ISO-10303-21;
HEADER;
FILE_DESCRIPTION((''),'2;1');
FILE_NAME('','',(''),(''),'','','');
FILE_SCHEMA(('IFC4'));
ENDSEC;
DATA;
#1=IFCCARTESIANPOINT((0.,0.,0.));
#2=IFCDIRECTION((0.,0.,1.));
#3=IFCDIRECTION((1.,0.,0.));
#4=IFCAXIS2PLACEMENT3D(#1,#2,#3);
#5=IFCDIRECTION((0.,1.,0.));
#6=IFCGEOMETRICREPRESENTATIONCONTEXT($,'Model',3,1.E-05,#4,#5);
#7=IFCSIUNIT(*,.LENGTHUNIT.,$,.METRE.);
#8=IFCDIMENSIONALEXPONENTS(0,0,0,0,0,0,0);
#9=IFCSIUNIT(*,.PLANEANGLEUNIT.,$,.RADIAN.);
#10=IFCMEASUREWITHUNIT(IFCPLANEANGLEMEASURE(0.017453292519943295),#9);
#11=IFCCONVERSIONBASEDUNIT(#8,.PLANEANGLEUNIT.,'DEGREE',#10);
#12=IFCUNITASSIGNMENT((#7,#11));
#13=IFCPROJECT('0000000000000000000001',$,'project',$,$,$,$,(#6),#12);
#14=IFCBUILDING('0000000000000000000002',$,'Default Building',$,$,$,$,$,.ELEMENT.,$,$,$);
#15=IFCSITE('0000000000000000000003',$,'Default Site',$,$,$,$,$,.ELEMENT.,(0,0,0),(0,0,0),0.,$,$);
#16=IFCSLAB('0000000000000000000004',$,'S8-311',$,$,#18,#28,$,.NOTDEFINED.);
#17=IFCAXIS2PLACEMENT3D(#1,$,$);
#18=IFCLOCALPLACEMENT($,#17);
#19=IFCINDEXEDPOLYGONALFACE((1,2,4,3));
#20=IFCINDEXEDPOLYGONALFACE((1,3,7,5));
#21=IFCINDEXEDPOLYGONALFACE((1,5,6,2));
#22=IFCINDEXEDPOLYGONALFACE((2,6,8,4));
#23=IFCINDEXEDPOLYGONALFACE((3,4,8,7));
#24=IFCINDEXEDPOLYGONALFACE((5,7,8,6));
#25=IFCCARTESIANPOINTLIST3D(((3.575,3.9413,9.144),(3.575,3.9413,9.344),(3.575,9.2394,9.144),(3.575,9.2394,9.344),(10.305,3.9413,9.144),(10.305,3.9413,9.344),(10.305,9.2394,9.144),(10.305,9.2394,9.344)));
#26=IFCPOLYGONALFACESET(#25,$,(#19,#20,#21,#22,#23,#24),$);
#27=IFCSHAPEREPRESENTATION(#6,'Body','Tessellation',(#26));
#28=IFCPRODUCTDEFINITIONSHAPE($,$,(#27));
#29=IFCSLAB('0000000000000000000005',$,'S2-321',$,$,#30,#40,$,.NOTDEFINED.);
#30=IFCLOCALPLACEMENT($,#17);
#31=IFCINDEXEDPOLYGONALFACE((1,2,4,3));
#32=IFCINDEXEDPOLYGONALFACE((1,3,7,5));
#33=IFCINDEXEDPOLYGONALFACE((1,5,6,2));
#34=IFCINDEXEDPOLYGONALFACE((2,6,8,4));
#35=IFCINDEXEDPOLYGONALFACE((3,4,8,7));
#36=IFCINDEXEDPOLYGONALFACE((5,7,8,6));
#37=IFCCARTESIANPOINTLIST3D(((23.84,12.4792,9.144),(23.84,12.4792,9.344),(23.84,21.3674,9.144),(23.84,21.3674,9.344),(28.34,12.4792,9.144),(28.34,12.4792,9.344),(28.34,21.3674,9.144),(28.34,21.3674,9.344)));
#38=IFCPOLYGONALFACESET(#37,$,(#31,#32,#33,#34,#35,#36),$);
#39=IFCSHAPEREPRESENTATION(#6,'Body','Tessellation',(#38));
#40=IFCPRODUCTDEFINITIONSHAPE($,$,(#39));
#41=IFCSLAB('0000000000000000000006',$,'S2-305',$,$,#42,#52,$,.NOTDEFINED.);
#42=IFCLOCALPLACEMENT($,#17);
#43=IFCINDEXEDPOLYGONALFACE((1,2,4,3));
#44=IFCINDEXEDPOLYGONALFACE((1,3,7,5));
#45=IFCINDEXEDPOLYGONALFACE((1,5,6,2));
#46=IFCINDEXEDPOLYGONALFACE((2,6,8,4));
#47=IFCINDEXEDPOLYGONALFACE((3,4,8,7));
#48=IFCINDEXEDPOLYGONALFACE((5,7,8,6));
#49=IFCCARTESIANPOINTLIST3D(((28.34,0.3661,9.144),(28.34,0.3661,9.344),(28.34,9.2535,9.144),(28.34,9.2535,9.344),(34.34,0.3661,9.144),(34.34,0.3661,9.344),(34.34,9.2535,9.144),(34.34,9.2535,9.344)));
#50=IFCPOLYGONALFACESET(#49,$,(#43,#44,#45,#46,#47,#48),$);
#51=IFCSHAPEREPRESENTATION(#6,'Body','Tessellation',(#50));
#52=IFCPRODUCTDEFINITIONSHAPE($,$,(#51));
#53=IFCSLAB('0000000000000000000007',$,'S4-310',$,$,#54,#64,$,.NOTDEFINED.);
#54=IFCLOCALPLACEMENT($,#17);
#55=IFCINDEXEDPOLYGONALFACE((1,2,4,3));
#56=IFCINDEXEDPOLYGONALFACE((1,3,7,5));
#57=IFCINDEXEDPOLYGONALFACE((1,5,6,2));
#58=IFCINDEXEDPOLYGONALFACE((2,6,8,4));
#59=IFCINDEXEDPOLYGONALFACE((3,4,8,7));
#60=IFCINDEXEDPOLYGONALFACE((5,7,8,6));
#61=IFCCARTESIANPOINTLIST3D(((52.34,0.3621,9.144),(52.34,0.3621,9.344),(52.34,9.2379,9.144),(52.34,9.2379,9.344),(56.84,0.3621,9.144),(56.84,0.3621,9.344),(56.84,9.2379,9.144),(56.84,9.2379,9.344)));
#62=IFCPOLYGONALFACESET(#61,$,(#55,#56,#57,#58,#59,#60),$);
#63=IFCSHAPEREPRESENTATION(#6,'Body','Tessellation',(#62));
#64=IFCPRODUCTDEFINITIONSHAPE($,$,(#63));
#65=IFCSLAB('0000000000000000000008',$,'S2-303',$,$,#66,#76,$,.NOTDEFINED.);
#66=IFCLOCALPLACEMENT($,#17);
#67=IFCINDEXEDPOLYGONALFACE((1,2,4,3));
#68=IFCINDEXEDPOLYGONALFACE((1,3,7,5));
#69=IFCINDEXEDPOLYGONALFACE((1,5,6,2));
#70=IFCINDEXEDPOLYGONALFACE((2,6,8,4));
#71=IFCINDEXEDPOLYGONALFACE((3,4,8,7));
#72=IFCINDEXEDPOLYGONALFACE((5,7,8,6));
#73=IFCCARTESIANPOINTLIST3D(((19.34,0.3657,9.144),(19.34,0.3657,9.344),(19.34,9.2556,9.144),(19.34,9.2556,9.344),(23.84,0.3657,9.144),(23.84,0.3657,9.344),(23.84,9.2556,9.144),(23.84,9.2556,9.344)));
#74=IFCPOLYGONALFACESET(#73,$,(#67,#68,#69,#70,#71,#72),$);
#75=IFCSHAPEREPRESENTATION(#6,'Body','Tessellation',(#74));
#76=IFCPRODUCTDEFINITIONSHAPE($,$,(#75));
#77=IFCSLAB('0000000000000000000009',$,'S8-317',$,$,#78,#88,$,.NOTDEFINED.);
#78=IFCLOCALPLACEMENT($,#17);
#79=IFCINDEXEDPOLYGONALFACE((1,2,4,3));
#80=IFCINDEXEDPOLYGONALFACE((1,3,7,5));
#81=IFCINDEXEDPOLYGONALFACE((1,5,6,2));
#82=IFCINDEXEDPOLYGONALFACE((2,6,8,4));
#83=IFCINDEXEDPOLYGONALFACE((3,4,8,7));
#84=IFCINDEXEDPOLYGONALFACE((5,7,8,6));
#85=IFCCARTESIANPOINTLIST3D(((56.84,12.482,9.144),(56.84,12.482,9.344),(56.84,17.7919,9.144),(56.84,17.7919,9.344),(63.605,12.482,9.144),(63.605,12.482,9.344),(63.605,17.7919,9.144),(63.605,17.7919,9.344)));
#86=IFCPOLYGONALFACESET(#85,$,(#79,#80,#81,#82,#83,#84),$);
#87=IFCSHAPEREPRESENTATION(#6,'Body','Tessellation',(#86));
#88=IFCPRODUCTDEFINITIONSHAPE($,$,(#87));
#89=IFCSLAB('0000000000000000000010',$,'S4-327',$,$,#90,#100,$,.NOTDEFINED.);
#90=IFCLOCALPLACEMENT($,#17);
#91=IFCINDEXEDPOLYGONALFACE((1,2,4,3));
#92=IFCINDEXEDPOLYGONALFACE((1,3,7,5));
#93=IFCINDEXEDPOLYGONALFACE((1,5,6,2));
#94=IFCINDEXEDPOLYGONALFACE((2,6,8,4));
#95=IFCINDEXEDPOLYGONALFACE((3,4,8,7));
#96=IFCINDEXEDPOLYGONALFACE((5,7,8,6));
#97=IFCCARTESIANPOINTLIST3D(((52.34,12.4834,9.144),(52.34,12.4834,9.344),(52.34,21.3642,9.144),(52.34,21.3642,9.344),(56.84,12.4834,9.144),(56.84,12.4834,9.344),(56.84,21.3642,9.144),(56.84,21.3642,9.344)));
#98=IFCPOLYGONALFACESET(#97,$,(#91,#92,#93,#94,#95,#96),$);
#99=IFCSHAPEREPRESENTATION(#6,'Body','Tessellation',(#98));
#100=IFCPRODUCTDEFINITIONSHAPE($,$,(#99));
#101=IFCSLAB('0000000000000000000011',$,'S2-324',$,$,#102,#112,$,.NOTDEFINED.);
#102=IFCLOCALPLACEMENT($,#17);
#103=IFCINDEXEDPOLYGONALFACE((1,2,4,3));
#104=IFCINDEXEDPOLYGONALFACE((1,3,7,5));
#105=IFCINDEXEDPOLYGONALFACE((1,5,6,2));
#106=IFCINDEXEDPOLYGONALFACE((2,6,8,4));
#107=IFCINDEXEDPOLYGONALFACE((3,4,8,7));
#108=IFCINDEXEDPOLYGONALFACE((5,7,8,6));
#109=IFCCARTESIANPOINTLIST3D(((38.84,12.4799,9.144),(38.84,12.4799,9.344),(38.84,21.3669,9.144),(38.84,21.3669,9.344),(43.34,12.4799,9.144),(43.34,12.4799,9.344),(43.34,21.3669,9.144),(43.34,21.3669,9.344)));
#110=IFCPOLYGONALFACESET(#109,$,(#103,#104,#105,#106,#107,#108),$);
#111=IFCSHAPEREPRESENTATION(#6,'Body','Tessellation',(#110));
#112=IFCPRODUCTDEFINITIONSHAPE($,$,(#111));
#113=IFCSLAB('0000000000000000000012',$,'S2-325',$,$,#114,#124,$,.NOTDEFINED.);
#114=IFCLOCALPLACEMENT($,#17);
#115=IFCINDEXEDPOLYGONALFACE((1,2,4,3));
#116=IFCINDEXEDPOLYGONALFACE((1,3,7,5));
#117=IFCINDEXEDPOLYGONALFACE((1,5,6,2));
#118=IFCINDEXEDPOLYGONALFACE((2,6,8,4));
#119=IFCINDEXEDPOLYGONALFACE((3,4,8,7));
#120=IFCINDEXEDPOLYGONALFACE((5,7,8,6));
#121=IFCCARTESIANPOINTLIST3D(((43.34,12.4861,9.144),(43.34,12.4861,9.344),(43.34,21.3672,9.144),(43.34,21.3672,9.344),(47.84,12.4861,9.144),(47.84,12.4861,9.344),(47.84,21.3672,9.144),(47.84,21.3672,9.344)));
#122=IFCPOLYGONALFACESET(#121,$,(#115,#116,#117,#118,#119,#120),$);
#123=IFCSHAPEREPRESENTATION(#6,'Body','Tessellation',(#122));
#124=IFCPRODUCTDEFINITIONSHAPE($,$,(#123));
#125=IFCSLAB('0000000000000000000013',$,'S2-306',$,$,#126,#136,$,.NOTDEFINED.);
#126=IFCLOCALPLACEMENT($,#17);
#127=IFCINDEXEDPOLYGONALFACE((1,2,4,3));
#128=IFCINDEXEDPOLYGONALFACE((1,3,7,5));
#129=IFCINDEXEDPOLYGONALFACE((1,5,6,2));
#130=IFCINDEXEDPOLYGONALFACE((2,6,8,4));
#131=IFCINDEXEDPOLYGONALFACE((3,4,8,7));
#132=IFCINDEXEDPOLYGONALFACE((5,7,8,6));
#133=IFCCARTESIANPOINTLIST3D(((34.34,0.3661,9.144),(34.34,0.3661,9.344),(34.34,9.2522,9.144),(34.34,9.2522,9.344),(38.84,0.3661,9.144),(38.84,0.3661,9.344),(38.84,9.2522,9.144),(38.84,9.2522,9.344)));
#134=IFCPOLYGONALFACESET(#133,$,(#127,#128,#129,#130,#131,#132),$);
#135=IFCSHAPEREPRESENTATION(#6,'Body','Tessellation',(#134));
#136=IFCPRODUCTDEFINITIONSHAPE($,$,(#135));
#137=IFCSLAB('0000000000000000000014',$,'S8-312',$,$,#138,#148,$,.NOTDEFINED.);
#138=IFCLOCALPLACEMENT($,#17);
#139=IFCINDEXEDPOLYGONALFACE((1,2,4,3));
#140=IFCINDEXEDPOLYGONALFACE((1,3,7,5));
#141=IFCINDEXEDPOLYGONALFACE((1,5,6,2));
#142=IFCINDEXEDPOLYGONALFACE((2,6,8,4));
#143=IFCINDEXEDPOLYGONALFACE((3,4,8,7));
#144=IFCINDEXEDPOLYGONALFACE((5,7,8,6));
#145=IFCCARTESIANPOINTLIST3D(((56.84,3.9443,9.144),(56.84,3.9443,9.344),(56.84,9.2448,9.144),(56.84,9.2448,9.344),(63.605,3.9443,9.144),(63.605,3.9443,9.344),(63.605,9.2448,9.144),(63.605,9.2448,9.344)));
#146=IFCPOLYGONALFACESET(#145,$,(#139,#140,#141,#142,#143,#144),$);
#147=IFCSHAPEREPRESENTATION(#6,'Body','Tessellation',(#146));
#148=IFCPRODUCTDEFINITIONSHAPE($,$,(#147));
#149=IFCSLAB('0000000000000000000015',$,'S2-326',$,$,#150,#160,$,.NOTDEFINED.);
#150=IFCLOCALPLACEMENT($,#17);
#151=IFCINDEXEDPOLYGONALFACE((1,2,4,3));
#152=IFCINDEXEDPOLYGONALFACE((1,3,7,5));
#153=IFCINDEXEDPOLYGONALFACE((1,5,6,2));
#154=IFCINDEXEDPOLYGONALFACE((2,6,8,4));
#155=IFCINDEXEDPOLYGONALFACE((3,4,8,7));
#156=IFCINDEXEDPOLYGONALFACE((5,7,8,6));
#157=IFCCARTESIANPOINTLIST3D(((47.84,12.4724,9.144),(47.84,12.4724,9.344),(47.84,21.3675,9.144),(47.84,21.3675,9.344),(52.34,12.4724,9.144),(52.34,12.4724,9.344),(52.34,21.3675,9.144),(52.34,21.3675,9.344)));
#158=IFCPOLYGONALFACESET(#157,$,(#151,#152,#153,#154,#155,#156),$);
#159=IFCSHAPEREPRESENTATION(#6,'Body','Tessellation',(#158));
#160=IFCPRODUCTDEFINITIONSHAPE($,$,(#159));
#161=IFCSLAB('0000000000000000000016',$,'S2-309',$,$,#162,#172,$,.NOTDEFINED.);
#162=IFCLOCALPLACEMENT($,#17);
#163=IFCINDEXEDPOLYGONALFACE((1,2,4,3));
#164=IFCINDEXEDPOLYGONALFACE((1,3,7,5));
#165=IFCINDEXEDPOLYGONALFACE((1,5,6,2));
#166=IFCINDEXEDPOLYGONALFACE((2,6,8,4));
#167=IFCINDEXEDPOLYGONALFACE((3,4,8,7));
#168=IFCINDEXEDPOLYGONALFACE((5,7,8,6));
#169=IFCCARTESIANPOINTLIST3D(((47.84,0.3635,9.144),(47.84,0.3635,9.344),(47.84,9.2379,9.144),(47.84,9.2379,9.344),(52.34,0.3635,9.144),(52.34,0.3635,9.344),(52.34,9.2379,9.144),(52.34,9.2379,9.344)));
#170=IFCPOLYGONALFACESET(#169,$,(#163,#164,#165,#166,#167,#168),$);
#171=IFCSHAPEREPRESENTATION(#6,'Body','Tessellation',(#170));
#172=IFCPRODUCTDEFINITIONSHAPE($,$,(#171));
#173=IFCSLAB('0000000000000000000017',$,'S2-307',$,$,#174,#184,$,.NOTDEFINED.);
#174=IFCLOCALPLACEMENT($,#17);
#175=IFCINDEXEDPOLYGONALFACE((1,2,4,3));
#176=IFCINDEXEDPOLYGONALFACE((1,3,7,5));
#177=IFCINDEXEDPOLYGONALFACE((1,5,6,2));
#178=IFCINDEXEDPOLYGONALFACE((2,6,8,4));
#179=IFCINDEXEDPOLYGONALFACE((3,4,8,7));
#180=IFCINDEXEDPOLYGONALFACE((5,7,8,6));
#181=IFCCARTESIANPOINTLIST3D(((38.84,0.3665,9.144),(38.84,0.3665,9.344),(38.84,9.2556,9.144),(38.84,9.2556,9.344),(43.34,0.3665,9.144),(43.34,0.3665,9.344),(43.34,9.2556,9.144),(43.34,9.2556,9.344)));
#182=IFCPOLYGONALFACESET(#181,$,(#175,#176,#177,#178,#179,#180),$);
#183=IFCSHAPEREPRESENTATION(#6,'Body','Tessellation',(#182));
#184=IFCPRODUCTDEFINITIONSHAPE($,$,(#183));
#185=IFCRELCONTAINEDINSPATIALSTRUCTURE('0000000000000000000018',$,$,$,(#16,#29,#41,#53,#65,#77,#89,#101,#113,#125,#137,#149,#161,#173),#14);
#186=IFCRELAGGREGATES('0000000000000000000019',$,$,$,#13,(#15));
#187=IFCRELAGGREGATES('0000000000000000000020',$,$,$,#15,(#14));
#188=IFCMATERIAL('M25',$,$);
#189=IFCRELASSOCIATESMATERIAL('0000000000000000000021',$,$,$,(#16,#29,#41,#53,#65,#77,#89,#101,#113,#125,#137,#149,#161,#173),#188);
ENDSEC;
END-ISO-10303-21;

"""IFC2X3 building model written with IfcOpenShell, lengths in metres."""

from ifc_helpers import new_model, entity, si_unit, converted_unit, direction, frame, frame_2d, origin_with_axes, place, context, project, spatial, rectangle, extrude, material, element, save


model = new_model("IFC2X3")

# Units and contexts
model_context = context("Model", 3, precision=1e-05, world=origin_with_axes(), true_north=direction((0.0, 1.0, 0.0)))
ifc_project = project(units=[si_unit("LENGTHUNIT", "METRE"), converted_unit("PLANEANGLEUNIT", "DEGREE", entity("IfcPlaneAngleMeasure", 0.017453292519943295), si_unit("PLANEANGLEUNIT", "RADIAN"), dimensions=[0, 0, 0, 0, 0, 0, 0])], contexts=[model_context])

# Site, building
site = spatial("IfcSite", under=ifc_project, Name="Default Site", CompositionType="ELEMENT", RefLatitude=(0, 0, 0), RefLongitude=(0, 0, 0), RefElevation=0.0)
building = spatial("IfcBuilding", under=site, Name="Default Building", CompositionType="ELEMENT")

# Shared definitions
ifc_material = material(Name="M25")
placement = place(None, origin_with_axes())

# Slabs
element("IfcSlab", 1, at=placement, inside=building, material=ifc_material, Name="S8-311", PredefinedType="NOTDEFINED", context=model_context, shape_type="SweptSolid", body=[
    extrude(rectangle(XDim=6.73, YDim=5.2982, at=frame_2d((0.0, 0.0), x_axis=(1.0, 0.0, 0.0))), frame((6.94, 6.5903, 9.144), z_axis=(0.0, 0.0, 1.0), x_axis=(1.0, 0.0, 0.0)), (0.0, 0.0, 1.0), 0.2),
])
element("IfcSlab", 2, at=placement, inside=building, material=ifc_material, Name="S2-321", PredefinedType="NOTDEFINED", context=model_context, shape_type="SweptSolid", body=[
    extrude(rectangle(XDim=4.5, YDim=8.8882, at=frame_2d((0.0, 0.0), x_axis=(1.0, 0.0, 0.0))), frame((26.09, 16.9233, 9.144), z_axis=(0.0, 0.0, 1.0), x_axis=(1.0, 0.0, 0.0)), (0.0, 0.0, 1.0), 0.2),
])
element("IfcSlab", 3, at=placement, inside=building, material=ifc_material, Name="S2-305", PredefinedType="NOTDEFINED", context=model_context, shape_type="SweptSolid", body=[
    extrude(rectangle(XDim=6.0, YDim=8.8874, at=frame_2d((0.0, 0.0), x_axis=(1.0, 0.0, 0.0))), frame((31.34, 4.8098, 9.144), z_axis=(0.0, 0.0, 1.0), x_axis=(1.0, 0.0, 0.0)), (0.0, 0.0, 1.0), 0.2),
])
element("IfcSlab", 4, at=placement, inside=building, material=ifc_material, Name="S4-310", PredefinedType="NOTDEFINED", context=model_context, shape_type="SweptSolid", body=[
    extrude(rectangle(XDim=4.5, YDim=8.8758, at=frame_2d((0.0, 0.0), x_axis=(1.0, 0.0, 0.0))), frame((54.59, 4.8, 9.144), z_axis=(0.0, 0.0, 1.0), x_axis=(1.0, 0.0, 0.0)), (0.0, 0.0, 1.0), 0.2),
])
element("IfcSlab", 5, at=placement, inside=building, material=ifc_material, Name="S2-303", PredefinedType="NOTDEFINED", context=model_context, shape_type="SweptSolid", body=[
    extrude(rectangle(XDim=4.5, YDim=8.89, at=frame_2d((0.0, 0.0), x_axis=(1.0, 0.0, 0.0))), frame((21.59, 4.8106, 9.144), z_axis=(0.0, 0.0, 1.0), x_axis=(1.0, 0.0, 0.0)), (0.0, 0.0, 1.0), 0.2),
])
element("IfcSlab", 6, at=placement, inside=building, material=ifc_material, Name="S8-317", PredefinedType="NOTDEFINED", context=model_context, shape_type="SweptSolid", body=[
    extrude(rectangle(XDim=6.765, YDim=5.3099, at=frame_2d((0.0, 0.0), x_axis=(1.0, 0.0, 0.0))), frame((60.2225, 15.1369, 9.144), z_axis=(0.0, 0.0, 1.0), x_axis=(1.0, 0.0, 0.0)), (0.0, 0.0, 1.0), 0.2),
])
element("IfcSlab", 7, at=placement, inside=building, material=ifc_material, Name="S4-327", PredefinedType="NOTDEFINED", context=model_context, shape_type="SweptSolid", body=[
    extrude(rectangle(XDim=4.5, YDim=8.8807, at=frame_2d((0.0, 0.0), x_axis=(1.0, 0.0, 0.0))), frame((54.59, 16.9238, 9.144), z_axis=(0.0, 0.0, 1.0), x_axis=(1.0, 0.0, 0.0)), (0.0, 0.0, 1.0), 0.2),
])
element("IfcSlab", 8, at=placement, inside=building, material=ifc_material, Name="S2-324", PredefinedType="NOTDEFINED", context=model_context, shape_type="SweptSolid", body=[
    extrude(rectangle(XDim=4.5, YDim=8.8871, at=frame_2d((0.0, 0.0), x_axis=(1.0, 0.0, 0.0))), frame((41.09, 16.9234, 9.144), z_axis=(0.0, 0.0, 1.0), x_axis=(1.0, 0.0, 0.0)), (0.0, 0.0, 1.0), 0.2),
])
element("IfcSlab", 9, at=placement, inside=building, material=ifc_material, Name="S2-325", PredefinedType="NOTDEFINED", context=model_context, shape_type="SweptSolid", body=[
    extrude(rectangle(XDim=4.5, YDim=8.8811, at=frame_2d((0.0, 0.0), x_axis=(1.0, 0.0, 0.0))), frame((45.59, 16.9266, 9.144), z_axis=(0.0, 0.0, 1.0), x_axis=(1.0, 0.0, 0.0)), (0.0, 0.0, 1.0), 0.2),
])
element("IfcSlab", 10, at=placement, inside=building, material=ifc_material, Name="S2-306", PredefinedType="NOTDEFINED", context=model_context, shape_type="SweptSolid", body=[
    extrude(rectangle(XDim=4.5, YDim=8.8861, at=frame_2d((0.0, 0.0), x_axis=(1.0, 0.0, 0.0))), frame((36.59, 4.8092, 9.144), z_axis=(0.0, 0.0, 1.0), x_axis=(1.0, 0.0, 0.0)), (0.0, 0.0, 1.0), 0.2),
])
element("IfcSlab", 11, at=placement, inside=building, material=ifc_material, Name="S8-312", PredefinedType="NOTDEFINED", context=model_context, shape_type="SweptSolid", body=[
    extrude(rectangle(XDim=6.765, YDim=5.3005, at=frame_2d((0.0, 0.0), x_axis=(1.0, 0.0, 0.0))), frame((60.2225, 6.5946, 9.144), z_axis=(0.0, 0.0, 1.0), x_axis=(1.0, 0.0, 0.0)), (0.0, 0.0, 1.0), 0.2),
])
element("IfcSlab", 12, at=placement, inside=building, material=ifc_material, Name="S2-326", PredefinedType="NOTDEFINED", context=model_context, shape_type="SweptSolid", body=[
    extrude(rectangle(XDim=4.5, YDim=8.8951, at=frame_2d((0.0, 0.0), x_axis=(1.0, 0.0, 0.0))), frame((50.09, 16.9199, 9.144), z_axis=(0.0, 0.0, 1.0), x_axis=(1.0, 0.0, 0.0)), (0.0, 0.0, 1.0), 0.2),
])
element("IfcSlab", 13, at=placement, inside=building, material=ifc_material, Name="S2-309", PredefinedType="NOTDEFINED", context=model_context, shape_type="SweptSolid", body=[
    extrude(rectangle(XDim=4.5, YDim=8.8744, at=frame_2d((0.0, 0.0), x_axis=(1.0, 0.0, 0.0))), frame((50.09, 4.8007, 9.144), z_axis=(0.0, 0.0, 1.0), x_axis=(1.0, 0.0, 0.0)), (0.0, 0.0, 1.0), 0.2),
])
element("IfcSlab", 14, at=placement, inside=building, material=ifc_material, Name="S2-307", PredefinedType="NOTDEFINED", context=model_context, shape_type="SweptSolid", body=[
    extrude(rectangle(XDim=4.5, YDim=8.8891, at=frame_2d((0.0, 0.0), x_axis=(1.0, 0.0, 0.0))), frame((41.09, 4.811, 9.144), z_axis=(0.0, 0.0, 1.0), x_axis=(1.0, 0.0, 0.0)), (0.0, 0.0, 1.0), 0.2),
])

save(model, "model.ifc")
